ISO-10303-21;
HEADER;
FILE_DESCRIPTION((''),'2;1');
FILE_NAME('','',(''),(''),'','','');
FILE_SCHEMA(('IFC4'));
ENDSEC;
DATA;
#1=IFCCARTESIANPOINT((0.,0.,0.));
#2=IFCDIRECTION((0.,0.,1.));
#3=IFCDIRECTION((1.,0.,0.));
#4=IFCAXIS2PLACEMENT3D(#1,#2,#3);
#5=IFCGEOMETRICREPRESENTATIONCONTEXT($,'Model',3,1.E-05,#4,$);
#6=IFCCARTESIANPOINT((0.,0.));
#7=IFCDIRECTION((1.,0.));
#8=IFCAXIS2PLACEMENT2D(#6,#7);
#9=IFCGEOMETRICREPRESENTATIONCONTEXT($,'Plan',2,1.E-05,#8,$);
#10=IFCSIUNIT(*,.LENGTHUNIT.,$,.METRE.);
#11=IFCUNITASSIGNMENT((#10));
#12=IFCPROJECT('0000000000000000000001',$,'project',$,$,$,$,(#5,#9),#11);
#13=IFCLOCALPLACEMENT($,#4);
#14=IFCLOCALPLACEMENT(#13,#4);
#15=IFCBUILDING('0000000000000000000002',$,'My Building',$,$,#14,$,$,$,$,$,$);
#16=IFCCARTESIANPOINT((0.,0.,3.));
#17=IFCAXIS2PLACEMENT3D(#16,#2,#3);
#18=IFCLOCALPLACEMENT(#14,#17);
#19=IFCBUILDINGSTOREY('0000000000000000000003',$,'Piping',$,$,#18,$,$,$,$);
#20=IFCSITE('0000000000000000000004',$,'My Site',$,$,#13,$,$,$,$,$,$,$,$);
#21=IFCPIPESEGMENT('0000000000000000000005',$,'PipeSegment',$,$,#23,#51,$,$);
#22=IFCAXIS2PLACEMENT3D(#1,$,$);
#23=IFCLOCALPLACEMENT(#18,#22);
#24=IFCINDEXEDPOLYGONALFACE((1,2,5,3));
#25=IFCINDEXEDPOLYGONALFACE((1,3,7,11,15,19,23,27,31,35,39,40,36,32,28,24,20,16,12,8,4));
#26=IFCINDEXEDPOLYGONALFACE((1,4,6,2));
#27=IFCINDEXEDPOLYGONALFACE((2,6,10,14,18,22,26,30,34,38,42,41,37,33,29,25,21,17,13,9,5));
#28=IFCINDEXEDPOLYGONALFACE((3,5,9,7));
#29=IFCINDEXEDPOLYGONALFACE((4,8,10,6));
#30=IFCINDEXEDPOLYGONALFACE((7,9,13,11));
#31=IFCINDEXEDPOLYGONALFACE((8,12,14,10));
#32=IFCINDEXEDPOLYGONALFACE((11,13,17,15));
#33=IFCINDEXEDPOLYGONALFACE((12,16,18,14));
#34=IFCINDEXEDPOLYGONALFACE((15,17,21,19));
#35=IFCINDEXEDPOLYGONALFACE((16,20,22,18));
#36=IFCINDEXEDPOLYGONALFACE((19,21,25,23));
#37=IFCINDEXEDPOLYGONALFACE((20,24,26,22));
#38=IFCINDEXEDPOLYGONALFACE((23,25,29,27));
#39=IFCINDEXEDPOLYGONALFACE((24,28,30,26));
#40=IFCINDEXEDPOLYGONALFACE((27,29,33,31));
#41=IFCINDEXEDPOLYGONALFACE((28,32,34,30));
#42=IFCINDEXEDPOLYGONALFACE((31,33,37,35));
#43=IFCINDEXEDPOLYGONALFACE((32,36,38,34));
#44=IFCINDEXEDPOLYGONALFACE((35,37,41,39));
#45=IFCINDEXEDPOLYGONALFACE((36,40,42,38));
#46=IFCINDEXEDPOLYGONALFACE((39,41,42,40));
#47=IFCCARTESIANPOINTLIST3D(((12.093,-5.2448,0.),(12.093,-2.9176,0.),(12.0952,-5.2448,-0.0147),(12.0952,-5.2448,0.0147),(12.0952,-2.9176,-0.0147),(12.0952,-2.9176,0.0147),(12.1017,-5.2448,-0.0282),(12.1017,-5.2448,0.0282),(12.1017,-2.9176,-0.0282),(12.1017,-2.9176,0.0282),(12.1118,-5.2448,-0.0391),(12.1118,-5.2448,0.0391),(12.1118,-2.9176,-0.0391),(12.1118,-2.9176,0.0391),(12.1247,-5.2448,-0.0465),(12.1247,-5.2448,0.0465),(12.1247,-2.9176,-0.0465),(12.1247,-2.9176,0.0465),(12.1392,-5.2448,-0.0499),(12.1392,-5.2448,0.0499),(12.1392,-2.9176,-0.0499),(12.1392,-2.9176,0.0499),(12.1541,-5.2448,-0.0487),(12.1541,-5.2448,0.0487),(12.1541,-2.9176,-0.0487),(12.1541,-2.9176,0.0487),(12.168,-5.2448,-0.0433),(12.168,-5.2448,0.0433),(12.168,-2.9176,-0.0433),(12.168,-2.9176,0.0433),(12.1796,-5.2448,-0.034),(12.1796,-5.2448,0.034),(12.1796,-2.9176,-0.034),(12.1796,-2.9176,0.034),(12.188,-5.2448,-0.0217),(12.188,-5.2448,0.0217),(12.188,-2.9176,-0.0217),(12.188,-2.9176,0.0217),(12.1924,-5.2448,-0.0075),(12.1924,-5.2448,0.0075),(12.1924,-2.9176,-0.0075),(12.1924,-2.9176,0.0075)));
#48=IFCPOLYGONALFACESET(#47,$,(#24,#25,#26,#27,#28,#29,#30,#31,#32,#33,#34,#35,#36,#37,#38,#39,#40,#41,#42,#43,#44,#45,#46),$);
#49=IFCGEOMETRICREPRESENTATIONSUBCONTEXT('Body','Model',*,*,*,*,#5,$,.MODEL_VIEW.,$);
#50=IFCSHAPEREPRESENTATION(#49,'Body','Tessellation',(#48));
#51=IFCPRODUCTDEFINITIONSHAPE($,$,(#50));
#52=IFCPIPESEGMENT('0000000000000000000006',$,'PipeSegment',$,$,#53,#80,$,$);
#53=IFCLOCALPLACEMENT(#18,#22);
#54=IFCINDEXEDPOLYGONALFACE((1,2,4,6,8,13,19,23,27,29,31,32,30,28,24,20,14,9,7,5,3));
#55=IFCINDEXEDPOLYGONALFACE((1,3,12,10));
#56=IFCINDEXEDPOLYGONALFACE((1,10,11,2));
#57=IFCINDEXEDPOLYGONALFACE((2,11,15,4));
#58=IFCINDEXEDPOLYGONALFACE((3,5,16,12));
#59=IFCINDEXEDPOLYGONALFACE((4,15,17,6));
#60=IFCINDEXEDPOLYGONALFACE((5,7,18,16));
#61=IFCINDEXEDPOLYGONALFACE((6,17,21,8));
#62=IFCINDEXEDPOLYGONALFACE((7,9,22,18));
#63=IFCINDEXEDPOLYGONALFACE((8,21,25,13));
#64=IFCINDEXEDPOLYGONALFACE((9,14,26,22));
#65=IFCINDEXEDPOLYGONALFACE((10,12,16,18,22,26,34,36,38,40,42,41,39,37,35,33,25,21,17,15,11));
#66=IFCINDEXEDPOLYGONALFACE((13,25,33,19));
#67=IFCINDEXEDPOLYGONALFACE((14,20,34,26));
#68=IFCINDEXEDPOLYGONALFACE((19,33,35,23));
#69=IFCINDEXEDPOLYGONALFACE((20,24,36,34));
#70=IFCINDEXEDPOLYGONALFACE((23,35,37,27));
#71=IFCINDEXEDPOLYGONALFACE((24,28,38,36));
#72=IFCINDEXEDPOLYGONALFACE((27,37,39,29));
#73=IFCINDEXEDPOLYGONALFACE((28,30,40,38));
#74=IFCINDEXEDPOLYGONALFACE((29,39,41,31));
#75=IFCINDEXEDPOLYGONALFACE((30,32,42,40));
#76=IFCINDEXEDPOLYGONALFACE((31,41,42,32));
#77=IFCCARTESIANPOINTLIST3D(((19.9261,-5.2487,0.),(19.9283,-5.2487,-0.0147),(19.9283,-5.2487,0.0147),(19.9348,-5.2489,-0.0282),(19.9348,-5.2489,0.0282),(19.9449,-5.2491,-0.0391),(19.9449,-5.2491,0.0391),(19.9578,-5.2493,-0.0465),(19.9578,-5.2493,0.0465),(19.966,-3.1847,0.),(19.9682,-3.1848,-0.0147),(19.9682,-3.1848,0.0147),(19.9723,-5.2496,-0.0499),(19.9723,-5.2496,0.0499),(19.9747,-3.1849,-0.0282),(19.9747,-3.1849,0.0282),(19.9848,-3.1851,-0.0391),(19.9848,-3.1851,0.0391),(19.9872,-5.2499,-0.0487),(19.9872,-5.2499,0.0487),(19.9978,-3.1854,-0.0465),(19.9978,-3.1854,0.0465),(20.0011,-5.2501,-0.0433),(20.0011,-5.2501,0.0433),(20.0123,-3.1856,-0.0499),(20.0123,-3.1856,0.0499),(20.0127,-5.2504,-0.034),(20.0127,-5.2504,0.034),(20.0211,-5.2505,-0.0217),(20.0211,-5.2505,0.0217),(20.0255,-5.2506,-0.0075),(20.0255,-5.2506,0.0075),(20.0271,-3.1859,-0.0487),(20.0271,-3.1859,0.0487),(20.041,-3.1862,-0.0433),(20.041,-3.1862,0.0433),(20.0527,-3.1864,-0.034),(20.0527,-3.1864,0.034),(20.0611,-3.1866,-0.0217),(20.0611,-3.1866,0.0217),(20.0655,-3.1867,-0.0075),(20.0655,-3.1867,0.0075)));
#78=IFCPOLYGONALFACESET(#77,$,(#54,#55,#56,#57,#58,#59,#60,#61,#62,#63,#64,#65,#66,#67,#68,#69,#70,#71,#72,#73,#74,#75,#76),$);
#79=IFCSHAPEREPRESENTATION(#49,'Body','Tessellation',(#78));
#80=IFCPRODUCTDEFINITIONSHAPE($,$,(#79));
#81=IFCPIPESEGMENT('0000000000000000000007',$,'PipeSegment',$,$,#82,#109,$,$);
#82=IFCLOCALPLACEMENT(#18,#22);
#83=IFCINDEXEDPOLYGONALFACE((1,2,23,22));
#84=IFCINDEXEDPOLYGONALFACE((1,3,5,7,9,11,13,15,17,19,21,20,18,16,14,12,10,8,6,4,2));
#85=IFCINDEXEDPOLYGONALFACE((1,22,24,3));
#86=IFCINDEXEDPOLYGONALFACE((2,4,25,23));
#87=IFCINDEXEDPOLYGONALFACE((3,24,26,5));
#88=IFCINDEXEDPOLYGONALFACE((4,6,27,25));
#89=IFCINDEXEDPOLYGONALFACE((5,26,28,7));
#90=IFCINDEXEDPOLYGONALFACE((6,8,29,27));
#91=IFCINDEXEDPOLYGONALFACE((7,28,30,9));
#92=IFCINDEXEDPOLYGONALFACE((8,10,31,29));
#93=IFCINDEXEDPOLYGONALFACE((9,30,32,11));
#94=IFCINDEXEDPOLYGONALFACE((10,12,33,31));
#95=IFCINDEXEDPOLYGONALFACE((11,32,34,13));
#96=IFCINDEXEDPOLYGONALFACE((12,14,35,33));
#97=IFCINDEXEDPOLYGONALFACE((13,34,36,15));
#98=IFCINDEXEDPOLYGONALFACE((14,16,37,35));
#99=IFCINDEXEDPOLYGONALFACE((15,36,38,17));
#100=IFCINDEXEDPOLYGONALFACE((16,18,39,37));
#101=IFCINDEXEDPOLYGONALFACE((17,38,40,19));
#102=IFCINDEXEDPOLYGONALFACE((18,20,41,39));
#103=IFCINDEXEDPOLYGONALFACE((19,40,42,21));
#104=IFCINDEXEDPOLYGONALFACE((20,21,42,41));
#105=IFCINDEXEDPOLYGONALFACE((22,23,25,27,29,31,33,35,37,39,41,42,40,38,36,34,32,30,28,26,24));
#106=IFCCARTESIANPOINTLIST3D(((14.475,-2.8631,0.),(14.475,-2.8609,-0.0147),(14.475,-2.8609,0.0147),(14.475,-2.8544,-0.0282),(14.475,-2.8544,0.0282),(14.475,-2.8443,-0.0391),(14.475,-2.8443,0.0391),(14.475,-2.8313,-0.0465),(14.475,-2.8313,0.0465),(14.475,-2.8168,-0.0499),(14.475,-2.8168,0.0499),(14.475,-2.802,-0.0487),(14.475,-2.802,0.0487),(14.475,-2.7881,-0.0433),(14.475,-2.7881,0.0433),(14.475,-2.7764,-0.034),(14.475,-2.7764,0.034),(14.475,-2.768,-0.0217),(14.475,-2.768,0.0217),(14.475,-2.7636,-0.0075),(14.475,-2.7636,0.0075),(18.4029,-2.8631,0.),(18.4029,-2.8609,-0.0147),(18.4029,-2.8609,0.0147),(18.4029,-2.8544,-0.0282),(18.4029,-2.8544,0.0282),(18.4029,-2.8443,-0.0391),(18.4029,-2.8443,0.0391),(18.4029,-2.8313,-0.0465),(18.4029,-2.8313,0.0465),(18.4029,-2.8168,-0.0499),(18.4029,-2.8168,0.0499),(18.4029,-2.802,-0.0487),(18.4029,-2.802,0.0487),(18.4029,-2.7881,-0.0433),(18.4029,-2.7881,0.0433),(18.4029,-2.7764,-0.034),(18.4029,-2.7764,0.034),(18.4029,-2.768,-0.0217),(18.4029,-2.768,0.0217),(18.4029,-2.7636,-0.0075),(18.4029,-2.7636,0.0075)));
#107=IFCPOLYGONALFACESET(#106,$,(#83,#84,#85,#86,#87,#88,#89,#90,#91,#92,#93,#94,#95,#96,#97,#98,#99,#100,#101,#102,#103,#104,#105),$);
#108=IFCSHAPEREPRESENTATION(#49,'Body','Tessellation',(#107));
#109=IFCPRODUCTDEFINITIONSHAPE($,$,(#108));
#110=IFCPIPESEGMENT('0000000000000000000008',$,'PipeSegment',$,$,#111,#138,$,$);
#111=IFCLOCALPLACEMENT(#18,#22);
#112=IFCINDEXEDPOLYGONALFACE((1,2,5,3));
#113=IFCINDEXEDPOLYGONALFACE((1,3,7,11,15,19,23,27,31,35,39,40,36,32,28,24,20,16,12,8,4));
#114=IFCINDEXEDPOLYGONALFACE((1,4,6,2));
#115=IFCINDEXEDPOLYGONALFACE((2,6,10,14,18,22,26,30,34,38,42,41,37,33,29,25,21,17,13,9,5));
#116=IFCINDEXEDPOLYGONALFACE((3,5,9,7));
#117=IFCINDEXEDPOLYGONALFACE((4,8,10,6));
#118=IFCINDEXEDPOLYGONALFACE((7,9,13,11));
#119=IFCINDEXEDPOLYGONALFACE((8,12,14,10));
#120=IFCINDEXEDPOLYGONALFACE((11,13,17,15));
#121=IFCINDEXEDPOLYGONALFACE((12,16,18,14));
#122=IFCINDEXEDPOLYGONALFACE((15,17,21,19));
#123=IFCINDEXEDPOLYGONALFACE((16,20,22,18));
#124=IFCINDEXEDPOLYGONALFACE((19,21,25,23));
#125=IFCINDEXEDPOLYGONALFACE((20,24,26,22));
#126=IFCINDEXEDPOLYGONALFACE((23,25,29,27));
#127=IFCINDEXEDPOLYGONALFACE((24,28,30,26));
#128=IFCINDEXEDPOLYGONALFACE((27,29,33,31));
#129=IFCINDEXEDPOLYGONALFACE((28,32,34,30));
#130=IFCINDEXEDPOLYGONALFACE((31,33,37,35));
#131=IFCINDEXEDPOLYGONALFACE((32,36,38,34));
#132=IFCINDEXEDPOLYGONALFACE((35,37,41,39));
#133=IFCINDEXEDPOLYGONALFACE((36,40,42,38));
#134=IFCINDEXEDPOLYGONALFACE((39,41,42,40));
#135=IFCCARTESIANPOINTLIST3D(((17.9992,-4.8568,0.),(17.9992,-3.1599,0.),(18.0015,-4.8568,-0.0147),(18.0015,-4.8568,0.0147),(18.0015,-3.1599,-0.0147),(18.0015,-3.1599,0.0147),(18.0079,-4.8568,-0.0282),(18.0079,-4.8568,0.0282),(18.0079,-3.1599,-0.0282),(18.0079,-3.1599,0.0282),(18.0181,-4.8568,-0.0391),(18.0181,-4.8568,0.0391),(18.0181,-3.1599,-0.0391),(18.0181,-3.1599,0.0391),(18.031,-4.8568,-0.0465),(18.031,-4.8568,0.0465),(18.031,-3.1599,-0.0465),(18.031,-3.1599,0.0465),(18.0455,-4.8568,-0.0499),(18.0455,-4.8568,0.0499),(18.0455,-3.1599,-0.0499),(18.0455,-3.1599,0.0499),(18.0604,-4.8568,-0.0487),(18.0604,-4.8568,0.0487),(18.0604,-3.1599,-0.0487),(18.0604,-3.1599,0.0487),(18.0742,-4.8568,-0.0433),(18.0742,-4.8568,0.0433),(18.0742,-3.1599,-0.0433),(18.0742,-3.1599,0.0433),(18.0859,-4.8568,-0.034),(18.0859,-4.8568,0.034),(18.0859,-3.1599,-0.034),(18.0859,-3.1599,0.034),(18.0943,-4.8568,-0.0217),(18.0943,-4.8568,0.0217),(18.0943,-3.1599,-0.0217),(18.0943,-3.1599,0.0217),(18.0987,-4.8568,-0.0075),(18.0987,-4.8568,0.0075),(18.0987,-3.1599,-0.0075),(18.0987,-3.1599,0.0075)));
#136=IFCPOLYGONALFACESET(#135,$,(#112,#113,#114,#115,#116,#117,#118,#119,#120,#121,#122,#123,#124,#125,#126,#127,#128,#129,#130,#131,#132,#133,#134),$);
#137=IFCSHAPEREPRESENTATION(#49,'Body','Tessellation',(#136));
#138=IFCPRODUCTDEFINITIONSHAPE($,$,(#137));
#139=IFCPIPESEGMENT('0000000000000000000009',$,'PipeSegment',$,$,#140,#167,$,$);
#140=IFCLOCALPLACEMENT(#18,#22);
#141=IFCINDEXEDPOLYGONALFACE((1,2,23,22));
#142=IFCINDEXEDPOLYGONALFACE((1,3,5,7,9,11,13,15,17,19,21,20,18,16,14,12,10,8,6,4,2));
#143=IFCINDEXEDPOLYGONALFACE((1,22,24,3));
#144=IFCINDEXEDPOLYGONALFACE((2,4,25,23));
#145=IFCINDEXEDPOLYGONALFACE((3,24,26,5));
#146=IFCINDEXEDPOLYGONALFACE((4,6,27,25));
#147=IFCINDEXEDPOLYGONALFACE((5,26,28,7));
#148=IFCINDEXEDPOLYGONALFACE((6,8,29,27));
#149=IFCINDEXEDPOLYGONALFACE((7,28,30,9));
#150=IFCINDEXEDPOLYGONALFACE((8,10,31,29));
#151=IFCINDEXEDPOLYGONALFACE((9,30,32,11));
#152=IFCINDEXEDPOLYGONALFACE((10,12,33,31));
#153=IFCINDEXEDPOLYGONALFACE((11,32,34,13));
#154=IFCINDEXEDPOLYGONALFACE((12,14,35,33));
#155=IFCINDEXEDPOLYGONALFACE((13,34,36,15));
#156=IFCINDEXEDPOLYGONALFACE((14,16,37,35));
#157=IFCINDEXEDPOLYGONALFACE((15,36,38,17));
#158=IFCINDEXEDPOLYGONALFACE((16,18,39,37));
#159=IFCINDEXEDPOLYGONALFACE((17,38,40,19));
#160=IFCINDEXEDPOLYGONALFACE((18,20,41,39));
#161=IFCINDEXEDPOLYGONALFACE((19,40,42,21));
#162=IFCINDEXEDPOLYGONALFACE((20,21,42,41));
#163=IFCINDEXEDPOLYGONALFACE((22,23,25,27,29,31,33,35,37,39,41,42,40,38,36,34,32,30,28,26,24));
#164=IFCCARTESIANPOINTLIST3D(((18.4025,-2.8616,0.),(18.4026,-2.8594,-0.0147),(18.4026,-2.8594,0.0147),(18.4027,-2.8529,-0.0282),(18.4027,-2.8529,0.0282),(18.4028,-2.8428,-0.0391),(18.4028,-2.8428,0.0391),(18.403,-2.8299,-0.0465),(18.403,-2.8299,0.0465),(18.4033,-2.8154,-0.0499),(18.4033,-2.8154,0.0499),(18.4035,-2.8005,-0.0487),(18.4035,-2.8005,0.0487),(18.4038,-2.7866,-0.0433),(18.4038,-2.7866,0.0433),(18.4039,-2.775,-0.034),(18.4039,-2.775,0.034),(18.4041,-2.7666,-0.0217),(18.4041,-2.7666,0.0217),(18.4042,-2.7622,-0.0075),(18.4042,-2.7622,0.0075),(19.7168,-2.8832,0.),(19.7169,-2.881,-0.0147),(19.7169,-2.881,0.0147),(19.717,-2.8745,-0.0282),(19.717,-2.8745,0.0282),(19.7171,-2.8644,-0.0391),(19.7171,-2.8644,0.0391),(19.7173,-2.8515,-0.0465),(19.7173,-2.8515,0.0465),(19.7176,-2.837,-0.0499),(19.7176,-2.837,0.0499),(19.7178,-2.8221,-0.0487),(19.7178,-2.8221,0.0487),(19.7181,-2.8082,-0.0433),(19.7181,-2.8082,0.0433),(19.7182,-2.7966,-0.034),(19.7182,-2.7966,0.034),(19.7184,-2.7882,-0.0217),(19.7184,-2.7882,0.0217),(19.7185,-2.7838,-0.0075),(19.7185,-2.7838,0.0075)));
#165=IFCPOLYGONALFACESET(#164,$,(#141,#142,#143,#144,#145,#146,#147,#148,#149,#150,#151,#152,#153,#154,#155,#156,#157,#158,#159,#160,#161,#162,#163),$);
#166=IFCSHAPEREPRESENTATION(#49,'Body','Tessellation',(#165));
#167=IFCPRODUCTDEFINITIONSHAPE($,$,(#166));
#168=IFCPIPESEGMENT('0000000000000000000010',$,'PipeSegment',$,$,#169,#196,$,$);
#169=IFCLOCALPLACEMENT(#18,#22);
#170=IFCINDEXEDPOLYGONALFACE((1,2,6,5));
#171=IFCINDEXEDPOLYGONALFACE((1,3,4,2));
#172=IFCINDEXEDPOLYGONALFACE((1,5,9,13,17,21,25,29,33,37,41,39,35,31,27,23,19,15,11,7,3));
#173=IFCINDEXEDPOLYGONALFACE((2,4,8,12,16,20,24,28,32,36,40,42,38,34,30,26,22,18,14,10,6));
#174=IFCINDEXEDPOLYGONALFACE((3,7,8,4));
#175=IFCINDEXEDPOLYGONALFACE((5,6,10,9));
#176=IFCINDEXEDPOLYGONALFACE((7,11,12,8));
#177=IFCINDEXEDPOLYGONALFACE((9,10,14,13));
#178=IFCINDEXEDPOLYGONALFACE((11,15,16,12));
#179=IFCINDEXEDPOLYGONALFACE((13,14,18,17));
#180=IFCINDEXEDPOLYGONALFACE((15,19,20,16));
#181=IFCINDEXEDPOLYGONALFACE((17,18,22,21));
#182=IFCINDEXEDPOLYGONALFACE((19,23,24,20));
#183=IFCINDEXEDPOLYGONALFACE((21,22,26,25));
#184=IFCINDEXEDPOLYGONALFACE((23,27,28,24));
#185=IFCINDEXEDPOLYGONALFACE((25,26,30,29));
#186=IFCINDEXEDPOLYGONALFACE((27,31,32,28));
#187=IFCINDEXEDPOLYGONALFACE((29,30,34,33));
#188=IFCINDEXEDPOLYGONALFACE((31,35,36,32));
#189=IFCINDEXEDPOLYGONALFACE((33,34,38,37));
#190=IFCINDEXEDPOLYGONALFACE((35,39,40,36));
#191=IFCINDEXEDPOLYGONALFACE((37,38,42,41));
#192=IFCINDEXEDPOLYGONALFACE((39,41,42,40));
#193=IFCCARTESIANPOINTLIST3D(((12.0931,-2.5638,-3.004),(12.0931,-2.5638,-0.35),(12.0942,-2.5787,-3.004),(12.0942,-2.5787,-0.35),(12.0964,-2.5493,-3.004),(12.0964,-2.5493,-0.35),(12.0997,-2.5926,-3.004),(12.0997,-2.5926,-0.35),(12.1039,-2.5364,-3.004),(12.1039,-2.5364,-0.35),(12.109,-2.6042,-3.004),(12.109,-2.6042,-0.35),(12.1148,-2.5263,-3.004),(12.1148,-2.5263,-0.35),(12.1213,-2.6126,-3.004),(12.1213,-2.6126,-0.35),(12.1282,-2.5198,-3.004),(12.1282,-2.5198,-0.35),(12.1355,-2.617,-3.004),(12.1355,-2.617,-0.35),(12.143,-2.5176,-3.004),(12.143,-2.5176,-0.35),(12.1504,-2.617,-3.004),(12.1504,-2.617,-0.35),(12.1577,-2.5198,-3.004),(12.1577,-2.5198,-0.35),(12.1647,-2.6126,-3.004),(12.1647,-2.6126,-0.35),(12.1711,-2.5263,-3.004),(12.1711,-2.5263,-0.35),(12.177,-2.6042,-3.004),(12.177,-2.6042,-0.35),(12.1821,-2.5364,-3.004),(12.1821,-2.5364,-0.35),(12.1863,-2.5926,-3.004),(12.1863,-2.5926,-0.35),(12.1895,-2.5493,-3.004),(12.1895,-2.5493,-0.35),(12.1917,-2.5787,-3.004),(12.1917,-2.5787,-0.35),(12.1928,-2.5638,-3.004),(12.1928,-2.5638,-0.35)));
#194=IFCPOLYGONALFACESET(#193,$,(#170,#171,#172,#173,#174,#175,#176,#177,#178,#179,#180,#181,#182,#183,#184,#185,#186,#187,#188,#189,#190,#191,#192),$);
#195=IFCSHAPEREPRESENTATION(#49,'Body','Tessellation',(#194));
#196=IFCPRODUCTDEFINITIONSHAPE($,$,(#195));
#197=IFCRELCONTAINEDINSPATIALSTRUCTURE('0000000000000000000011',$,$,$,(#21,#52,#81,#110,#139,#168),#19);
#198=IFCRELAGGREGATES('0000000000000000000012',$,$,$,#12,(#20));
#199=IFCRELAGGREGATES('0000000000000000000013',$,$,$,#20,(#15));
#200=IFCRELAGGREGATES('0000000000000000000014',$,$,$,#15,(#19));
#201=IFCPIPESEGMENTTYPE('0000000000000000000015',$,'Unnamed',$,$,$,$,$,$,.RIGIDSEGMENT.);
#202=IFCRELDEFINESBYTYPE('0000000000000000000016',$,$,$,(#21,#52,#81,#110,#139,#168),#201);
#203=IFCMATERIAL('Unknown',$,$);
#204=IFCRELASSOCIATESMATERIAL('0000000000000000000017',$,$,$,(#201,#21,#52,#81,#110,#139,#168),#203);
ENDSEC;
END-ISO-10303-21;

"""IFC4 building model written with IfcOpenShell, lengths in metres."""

from ifc_helpers import new_model, si_unit, frame, origin_with_axes, origin_2d_with_axis, place, context, subcontext, project, spatial, circle, extrude, material, material_profile, profile_set, profile_usage, type_object, element, save


model = new_model("IFC4")

# Units and contexts
model_context = context("Model", 3, precision=1e-05, world=origin_with_axes())
plan_context = context("Plan", 2, precision=1e-05, world=origin_2d_with_axis())
body_context = subcontext(model_context, "Body", "Model", "MODEL_VIEW")
ifc_project = project(units=[si_unit("LENGTHUNIT", "METRE")], contexts=[model_context, plan_context])

# Site, building, storey
site_placement = place(None, origin_with_axes())
site = spatial("IfcSite", under=ifc_project, at=site_placement, Name="My Site")
building_placement = place(site_placement, origin_with_axes())
building = spatial("IfcBuilding", under=site, at=building_placement, Name="My Building")
storey_placement = place(building_placement, frame((0.0, 0.0, 3.0), z_axis=(0.0, 0.0, 1.0), x_axis=(1.0, 0.0, 0.0)))
storey = spatial("IfcBuildingStorey", under=building, at=storey_placement, Name="Piping")

# Pipe segments
ifc_material = material(Name="Unknown")
ifc_material_profile = material_profile(ifc_material, circle(Radius=0.05))
ifc_profile_set = profile_set([ifc_material_profile])
ifc_profile_usage_1 = profile_usage(ifc_profile_set, cardinal=5)
pipe_segment_type = type_object("IfcPipeSegmentType", Name="Unnamed", PredefinedType="RIGIDSEGMENT", material=ifc_profile_set)
pipe_segment_1_placement = place(storey_placement, frame((12.143, -5.2448, 0.0), z_axis=(0.0, 1.0, 0.0), x_axis=(-1.0, 0.0, 0.0)))
element("IfcPipeSegment", 1, at=pipe_segment_1_placement, inside=storey, type_object=pipe_segment_type, material=ifc_profile_usage_1, Name="PipeSegment", context=body_context, shape_type="SweptSolid", body=[
    extrude(circle(Radius=0.05), origin_with_axes(), (0.0, 0.0, 1.0), 2.3272),
])
ifc_profile_usage_2 = profile_usage(ifc_profile_set, cardinal=5)
pipe_segment_2_placement = place(storey_placement, frame((19.9761, -5.2497, 0.0), z_axis=(0.01935, 0.999813, 0.0), x_axis=(-0.999813, 0.01935, 0.0)))
element("IfcPipeSegment", 2, at=pipe_segment_2_placement, inside=storey, type_object=pipe_segment_type, material=ifc_profile_usage_2, Name="PipeSegment", context=body_context, shape_type="SweptSolid", body=[
    extrude(circle(Radius=0.05), origin_with_axes(), (0.0, 0.0, 1.0), 2.0643),
])
ifc_profile_usage_3 = profile_usage(ifc_profile_set, cardinal=5)
pipe_segment_3_placement = place(storey_placement, frame((18.4029, -2.8131, 0.0), z_axis=(-1.0, 0.0, 0.0), x_axis=(0.0, -1.0, 0.0)))
element("IfcPipeSegment", 3, at=pipe_segment_3_placement, inside=storey, type_object=pipe_segment_type, material=ifc_profile_usage_3, Name="PipeSegment", context=body_context, shape_type="SweptSolid", body=[
    extrude(circle(Radius=0.05), origin_with_axes(), (0.0, 0.0, 1.0), 3.9279),
])
ifc_profile_usage_4 = profile_usage(ifc_profile_set, cardinal=5)
pipe_segment_4_placement = place(storey_placement, frame((18.0492, -4.8568, 0.0), z_axis=(0.0, 1.0, 0.0), x_axis=(-1.0, 0.0, 0.0)))
element("IfcPipeSegment", 4, at=pipe_segment_4_placement, inside=storey, type_object=pipe_segment_type, material=ifc_profile_usage_4, Name="PipeSegment", context=body_context, shape_type="SweptSolid", body=[
    extrude(circle(Radius=0.05), origin_with_axes(), (0.0, 0.0, 1.0), 1.6968),
])
ifc_profile_usage_5 = profile_usage(ifc_profile_set, cardinal=5)
pipe_segment_5_placement = place(storey_placement, frame((19.7176, -2.8332, 0.0), z_axis=(-0.999865, 0.01644, 0.0), x_axis=(-0.01644, -0.999865, 0.0)))
element("IfcPipeSegment", 5, at=pipe_segment_5_placement, inside=storey, type_object=pipe_segment_type, material=ifc_profile_usage_5, Name="PipeSegment", context=body_context, shape_type="SweptSolid", body=[
    extrude(circle(Radius=0.05), origin_with_axes(), (0.0, 0.0, 1.0), 1.3145),
])
ifc_profile_usage_6 = profile_usage(ifc_profile_set, cardinal=5)
pipe_segment_6_placement = place(storey_placement, frame((12.143, -2.5676, -0.35), z_axis=(0.0, 0.0, -1.0), x_axis=(0.0, 1.0, 0.0)))
element("IfcPipeSegment", 6, at=pipe_segment_6_placement, inside=storey, type_object=pipe_segment_type, material=ifc_profile_usage_6, Name="PipeSegment", context=body_context, shape_type="SweptSolid", body=[
    extrude(circle(Radius=0.05), origin_with_axes(), (0.0, 0.0, 1.0), 2.654),
])

save(model, "model.ifc")
